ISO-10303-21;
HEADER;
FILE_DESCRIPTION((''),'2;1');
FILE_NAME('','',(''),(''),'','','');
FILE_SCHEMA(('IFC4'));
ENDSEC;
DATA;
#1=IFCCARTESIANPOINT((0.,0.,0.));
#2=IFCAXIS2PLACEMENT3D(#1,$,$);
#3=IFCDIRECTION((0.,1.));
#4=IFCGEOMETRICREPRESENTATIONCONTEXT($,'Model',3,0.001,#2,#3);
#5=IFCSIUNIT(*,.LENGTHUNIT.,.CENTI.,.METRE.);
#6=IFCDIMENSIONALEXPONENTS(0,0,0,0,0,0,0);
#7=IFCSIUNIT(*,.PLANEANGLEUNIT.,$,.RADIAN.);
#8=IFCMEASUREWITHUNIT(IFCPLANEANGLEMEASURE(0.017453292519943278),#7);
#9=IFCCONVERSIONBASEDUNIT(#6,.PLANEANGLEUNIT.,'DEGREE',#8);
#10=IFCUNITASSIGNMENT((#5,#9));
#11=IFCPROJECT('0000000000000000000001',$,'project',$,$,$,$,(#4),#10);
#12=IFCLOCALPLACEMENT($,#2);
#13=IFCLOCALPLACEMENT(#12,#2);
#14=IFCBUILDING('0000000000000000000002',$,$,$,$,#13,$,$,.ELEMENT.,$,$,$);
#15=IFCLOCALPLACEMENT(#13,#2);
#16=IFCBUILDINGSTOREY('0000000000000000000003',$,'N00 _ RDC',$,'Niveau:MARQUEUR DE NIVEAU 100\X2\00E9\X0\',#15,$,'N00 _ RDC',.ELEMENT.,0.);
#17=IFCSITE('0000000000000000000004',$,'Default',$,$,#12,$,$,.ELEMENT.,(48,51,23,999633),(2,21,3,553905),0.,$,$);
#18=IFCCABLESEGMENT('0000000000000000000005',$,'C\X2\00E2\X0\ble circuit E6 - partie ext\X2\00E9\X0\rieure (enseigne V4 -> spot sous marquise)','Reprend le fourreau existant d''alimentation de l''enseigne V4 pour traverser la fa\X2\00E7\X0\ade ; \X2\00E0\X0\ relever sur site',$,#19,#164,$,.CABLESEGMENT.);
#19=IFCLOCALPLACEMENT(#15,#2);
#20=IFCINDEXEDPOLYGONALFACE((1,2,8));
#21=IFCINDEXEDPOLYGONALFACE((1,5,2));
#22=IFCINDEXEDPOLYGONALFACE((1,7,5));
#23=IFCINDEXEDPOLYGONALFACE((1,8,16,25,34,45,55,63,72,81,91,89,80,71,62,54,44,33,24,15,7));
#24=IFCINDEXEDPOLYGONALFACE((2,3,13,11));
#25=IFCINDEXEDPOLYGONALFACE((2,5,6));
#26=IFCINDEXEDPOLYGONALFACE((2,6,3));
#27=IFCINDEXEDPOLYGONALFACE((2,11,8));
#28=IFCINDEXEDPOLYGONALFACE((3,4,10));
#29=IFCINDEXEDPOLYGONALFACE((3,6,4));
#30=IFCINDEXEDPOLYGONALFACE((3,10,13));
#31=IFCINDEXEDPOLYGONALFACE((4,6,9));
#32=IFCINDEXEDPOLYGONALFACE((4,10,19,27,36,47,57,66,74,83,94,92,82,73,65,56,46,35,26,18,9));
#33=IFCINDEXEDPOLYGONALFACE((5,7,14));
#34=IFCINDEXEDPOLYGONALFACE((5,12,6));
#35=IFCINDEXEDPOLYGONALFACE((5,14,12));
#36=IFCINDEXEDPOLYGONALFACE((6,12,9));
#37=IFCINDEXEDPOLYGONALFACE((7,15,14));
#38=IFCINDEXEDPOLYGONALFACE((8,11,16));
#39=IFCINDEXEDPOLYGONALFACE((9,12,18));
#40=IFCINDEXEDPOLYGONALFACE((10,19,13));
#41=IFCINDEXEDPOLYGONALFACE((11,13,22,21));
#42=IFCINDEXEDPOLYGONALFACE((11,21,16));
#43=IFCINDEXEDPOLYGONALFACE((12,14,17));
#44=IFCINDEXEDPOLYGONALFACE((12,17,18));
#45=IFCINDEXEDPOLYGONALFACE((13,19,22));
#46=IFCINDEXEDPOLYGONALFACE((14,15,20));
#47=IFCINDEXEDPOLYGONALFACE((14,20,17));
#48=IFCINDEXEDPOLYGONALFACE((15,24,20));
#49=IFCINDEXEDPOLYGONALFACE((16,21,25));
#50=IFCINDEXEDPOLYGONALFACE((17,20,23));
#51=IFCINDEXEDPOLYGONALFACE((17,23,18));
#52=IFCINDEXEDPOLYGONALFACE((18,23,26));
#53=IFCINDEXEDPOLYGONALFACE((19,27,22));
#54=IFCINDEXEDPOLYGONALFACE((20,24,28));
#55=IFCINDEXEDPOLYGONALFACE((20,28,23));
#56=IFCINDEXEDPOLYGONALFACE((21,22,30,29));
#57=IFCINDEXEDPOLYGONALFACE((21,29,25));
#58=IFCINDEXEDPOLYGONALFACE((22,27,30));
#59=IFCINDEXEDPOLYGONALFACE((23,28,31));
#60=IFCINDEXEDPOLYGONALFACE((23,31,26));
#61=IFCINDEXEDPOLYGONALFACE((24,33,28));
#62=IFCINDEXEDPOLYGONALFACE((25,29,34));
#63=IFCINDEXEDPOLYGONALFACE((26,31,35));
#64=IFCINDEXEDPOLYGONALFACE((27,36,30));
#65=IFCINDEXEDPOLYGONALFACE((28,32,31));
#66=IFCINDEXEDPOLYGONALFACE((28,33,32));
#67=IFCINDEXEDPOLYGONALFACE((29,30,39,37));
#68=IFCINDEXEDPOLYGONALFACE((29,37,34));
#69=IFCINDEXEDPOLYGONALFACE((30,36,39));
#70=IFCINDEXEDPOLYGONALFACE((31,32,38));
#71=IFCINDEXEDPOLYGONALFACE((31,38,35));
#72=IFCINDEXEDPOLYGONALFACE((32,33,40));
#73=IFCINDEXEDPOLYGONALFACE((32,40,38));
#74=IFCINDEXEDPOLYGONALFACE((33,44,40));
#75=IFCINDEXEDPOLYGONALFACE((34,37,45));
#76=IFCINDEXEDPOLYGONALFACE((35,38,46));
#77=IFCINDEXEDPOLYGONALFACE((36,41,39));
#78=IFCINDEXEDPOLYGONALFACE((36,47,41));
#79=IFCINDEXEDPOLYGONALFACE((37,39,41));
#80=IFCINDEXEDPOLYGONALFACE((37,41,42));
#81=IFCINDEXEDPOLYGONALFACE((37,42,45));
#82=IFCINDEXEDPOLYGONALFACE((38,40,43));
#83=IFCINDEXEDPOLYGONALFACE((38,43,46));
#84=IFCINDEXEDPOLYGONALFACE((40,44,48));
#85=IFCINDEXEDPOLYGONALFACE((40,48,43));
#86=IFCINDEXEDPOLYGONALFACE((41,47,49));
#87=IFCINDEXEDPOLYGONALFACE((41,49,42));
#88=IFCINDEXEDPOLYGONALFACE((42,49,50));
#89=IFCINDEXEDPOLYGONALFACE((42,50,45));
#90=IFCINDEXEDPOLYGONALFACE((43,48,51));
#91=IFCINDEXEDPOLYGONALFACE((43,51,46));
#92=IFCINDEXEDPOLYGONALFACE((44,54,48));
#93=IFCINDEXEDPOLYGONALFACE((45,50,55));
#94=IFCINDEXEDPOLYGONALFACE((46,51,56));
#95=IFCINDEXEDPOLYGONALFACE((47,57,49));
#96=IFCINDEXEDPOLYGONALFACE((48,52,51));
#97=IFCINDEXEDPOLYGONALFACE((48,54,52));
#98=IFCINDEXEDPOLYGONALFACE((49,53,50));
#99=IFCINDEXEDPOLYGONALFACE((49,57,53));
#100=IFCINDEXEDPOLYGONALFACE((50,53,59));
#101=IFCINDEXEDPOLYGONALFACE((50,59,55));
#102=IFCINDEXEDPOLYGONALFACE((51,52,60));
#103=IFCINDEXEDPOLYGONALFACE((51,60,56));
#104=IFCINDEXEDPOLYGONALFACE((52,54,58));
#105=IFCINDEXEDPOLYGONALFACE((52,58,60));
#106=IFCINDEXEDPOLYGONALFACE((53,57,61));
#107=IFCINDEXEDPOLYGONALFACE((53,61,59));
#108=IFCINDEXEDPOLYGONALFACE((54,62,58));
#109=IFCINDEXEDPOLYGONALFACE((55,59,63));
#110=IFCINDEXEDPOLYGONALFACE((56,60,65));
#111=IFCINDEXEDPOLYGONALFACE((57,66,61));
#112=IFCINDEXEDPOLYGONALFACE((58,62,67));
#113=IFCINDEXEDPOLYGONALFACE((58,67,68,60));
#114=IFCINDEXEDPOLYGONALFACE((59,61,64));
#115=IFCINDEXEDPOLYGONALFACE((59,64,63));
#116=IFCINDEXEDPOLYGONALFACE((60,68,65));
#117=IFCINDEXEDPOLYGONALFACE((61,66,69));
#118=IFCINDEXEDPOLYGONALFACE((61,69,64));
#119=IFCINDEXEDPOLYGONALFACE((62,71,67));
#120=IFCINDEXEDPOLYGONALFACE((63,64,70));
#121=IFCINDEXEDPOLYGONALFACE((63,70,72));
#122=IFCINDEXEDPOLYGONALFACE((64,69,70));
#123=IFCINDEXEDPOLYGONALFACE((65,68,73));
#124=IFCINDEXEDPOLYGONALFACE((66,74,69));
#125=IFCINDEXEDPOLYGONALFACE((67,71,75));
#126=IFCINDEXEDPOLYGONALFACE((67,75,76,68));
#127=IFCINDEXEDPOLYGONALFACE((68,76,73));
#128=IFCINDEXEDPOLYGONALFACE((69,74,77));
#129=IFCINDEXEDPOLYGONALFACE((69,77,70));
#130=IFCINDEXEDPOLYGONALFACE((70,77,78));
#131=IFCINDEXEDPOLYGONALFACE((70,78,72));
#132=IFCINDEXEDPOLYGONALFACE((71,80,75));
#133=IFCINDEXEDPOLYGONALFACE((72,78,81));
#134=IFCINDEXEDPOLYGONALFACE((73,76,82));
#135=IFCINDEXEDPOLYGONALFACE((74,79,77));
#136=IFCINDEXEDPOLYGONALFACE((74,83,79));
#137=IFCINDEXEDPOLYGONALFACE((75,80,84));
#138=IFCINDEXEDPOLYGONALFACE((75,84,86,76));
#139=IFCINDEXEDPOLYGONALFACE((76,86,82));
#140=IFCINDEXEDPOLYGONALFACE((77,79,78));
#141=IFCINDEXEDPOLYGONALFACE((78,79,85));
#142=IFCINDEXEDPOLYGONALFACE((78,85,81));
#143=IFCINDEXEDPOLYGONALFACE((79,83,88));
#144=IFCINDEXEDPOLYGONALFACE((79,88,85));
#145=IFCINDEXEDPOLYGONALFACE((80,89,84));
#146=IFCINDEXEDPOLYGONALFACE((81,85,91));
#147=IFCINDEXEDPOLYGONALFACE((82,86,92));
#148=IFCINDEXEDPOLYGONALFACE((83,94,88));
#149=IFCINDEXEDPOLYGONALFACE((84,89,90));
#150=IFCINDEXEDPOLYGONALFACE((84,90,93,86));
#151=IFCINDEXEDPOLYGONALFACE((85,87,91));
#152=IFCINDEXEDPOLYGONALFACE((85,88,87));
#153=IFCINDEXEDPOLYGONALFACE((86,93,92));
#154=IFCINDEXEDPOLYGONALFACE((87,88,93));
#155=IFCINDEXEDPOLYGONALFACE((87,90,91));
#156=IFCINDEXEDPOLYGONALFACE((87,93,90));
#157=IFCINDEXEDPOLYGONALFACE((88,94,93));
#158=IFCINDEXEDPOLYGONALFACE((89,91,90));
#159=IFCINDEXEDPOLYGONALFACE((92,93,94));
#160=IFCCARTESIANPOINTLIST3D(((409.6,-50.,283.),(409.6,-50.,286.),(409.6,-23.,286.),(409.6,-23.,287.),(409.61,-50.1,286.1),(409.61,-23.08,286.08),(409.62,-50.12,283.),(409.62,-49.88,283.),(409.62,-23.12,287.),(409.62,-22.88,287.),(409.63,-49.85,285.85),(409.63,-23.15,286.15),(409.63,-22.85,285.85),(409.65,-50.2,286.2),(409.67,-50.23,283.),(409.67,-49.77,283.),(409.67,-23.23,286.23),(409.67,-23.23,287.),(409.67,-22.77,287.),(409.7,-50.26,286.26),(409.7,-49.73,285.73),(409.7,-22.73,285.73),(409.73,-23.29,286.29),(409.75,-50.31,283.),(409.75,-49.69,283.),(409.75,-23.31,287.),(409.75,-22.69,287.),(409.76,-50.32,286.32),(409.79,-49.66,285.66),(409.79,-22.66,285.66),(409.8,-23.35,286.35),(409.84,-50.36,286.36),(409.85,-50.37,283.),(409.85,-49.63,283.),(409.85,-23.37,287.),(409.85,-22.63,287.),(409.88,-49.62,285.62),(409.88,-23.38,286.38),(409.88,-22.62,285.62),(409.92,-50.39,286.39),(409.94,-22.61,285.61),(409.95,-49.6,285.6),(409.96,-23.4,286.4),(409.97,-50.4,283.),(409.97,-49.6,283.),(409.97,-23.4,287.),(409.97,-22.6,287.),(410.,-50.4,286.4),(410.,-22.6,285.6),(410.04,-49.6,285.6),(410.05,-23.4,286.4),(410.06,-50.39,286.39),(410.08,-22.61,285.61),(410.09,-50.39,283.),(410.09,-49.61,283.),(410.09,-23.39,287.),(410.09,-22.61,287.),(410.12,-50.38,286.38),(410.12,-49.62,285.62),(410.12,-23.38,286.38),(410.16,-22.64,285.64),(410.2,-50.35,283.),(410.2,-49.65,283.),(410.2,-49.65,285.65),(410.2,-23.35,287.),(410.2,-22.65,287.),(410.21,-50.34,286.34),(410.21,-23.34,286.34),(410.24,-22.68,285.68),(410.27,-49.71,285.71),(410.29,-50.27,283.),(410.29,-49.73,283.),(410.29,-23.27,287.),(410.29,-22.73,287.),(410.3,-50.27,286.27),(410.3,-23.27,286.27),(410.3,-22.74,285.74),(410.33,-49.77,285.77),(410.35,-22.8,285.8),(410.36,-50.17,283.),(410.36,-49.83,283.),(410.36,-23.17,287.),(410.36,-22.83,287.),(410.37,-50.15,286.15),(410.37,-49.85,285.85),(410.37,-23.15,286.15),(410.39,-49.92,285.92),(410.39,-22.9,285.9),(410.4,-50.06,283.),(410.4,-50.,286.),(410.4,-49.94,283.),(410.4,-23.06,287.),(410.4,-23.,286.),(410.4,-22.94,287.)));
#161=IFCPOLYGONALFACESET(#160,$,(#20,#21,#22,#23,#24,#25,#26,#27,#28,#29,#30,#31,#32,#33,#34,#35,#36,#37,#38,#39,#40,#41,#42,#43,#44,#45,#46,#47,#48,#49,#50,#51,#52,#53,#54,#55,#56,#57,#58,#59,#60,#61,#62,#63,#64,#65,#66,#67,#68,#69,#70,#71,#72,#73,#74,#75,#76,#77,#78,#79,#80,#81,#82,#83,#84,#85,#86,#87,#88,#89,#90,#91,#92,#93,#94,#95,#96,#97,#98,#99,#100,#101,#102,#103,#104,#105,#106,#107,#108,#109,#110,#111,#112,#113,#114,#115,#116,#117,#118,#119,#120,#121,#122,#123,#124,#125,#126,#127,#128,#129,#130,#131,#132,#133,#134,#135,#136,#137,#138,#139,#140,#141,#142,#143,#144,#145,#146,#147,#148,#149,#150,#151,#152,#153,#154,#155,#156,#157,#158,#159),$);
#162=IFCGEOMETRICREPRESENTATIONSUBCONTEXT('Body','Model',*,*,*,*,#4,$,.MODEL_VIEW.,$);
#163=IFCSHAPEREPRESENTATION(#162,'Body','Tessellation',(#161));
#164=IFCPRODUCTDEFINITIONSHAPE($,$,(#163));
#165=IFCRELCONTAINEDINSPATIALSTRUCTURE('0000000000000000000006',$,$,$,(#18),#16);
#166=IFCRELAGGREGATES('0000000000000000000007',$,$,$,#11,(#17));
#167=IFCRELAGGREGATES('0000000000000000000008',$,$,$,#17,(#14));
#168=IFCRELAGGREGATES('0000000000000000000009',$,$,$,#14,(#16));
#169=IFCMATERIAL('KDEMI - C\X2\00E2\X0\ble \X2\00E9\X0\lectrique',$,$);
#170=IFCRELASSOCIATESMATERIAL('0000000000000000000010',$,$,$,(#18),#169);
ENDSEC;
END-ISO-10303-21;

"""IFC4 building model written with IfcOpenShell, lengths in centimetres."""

from ifc_helpers import new_model, entity, si_unit, converted_unit, direction, origin, origin_with_axes, place, context, subcontext, project, spatial, material, element, save


model = new_model("IFC4")

# Units and contexts
model_context = context("Model", 3, precision=0.001, world=origin(), true_north=direction((0.0, 1.0)))
body_context = subcontext(model_context, "Body", "Model", "MODEL_VIEW")
ifc_project = project(units=[si_unit("LENGTHUNIT", "METRE", prefix="CENTI"), converted_unit("PLANEANGLEUNIT", "DEGREE", entity("IfcPlaneAngleMeasure", 0.017453292519943278), si_unit("PLANEANGLEUNIT", "RADIAN"), dimensions=[0, 0, 0, 0, 0, 0, 0])], contexts=[model_context])

# Site, building, storey
site_placement = place(None, origin())
site = spatial("IfcSite", under=ifc_project, at=site_placement, Name="Default", CompositionType="ELEMENT", RefLatitude=(48, 51, 23, 999633), RefLongitude=(2, 21, 3, 553905), RefElevation=0.0)
building_placement = place(site_placement, origin())
building = spatial("IfcBuilding", under=site, at=building_placement, CompositionType="ELEMENT")
storey_placement = place(building_placement, origin())
storey = spatial("IfcBuildingStorey", under=building, at=storey_placement, Name="N00 _ RDC", ObjectType="Niveau:MARQUEUR DE NIVEAU 100é", LongName="N00 _ RDC", CompositionType="ELEMENT", Elevation=0.0)

# Cable segment
ifc_material_1 = material(Name="KDEMI - Câble électrique")
cable_segment_1_placement = place(storey_placement, origin_with_axes())
element("IfcCableSegment", 1, at=cable_segment_1_placement, inside=storey, material=ifc_material_1, Name="Câble circuit E6 - partie extérieure (enseigne V4 -> spot sous marquise)", Description="Reprend le fourreau existant d'alimentation de l'enseigne V4 pour traverser la façade ; à relever sur site", PredefinedType="CABLESEGMENT", context=body_context, shape_type="AdvancedSweptSolid", body=[
    entity("IfcSweptDiskSolid", entity("IfcPolyline", [entity("IfcCartesianPoint", [410.0, -23.0, 287.0]), entity("IfcCartesianPoint", [410.0, -23.0, 286.0]), entity("IfcCartesianPoint", [410.0, -50.0, 286.0]), entity("IfcCartesianPoint", [410.0, -50.0, 283.0])]), 0.4),
])

save(model, "model.ifc")
